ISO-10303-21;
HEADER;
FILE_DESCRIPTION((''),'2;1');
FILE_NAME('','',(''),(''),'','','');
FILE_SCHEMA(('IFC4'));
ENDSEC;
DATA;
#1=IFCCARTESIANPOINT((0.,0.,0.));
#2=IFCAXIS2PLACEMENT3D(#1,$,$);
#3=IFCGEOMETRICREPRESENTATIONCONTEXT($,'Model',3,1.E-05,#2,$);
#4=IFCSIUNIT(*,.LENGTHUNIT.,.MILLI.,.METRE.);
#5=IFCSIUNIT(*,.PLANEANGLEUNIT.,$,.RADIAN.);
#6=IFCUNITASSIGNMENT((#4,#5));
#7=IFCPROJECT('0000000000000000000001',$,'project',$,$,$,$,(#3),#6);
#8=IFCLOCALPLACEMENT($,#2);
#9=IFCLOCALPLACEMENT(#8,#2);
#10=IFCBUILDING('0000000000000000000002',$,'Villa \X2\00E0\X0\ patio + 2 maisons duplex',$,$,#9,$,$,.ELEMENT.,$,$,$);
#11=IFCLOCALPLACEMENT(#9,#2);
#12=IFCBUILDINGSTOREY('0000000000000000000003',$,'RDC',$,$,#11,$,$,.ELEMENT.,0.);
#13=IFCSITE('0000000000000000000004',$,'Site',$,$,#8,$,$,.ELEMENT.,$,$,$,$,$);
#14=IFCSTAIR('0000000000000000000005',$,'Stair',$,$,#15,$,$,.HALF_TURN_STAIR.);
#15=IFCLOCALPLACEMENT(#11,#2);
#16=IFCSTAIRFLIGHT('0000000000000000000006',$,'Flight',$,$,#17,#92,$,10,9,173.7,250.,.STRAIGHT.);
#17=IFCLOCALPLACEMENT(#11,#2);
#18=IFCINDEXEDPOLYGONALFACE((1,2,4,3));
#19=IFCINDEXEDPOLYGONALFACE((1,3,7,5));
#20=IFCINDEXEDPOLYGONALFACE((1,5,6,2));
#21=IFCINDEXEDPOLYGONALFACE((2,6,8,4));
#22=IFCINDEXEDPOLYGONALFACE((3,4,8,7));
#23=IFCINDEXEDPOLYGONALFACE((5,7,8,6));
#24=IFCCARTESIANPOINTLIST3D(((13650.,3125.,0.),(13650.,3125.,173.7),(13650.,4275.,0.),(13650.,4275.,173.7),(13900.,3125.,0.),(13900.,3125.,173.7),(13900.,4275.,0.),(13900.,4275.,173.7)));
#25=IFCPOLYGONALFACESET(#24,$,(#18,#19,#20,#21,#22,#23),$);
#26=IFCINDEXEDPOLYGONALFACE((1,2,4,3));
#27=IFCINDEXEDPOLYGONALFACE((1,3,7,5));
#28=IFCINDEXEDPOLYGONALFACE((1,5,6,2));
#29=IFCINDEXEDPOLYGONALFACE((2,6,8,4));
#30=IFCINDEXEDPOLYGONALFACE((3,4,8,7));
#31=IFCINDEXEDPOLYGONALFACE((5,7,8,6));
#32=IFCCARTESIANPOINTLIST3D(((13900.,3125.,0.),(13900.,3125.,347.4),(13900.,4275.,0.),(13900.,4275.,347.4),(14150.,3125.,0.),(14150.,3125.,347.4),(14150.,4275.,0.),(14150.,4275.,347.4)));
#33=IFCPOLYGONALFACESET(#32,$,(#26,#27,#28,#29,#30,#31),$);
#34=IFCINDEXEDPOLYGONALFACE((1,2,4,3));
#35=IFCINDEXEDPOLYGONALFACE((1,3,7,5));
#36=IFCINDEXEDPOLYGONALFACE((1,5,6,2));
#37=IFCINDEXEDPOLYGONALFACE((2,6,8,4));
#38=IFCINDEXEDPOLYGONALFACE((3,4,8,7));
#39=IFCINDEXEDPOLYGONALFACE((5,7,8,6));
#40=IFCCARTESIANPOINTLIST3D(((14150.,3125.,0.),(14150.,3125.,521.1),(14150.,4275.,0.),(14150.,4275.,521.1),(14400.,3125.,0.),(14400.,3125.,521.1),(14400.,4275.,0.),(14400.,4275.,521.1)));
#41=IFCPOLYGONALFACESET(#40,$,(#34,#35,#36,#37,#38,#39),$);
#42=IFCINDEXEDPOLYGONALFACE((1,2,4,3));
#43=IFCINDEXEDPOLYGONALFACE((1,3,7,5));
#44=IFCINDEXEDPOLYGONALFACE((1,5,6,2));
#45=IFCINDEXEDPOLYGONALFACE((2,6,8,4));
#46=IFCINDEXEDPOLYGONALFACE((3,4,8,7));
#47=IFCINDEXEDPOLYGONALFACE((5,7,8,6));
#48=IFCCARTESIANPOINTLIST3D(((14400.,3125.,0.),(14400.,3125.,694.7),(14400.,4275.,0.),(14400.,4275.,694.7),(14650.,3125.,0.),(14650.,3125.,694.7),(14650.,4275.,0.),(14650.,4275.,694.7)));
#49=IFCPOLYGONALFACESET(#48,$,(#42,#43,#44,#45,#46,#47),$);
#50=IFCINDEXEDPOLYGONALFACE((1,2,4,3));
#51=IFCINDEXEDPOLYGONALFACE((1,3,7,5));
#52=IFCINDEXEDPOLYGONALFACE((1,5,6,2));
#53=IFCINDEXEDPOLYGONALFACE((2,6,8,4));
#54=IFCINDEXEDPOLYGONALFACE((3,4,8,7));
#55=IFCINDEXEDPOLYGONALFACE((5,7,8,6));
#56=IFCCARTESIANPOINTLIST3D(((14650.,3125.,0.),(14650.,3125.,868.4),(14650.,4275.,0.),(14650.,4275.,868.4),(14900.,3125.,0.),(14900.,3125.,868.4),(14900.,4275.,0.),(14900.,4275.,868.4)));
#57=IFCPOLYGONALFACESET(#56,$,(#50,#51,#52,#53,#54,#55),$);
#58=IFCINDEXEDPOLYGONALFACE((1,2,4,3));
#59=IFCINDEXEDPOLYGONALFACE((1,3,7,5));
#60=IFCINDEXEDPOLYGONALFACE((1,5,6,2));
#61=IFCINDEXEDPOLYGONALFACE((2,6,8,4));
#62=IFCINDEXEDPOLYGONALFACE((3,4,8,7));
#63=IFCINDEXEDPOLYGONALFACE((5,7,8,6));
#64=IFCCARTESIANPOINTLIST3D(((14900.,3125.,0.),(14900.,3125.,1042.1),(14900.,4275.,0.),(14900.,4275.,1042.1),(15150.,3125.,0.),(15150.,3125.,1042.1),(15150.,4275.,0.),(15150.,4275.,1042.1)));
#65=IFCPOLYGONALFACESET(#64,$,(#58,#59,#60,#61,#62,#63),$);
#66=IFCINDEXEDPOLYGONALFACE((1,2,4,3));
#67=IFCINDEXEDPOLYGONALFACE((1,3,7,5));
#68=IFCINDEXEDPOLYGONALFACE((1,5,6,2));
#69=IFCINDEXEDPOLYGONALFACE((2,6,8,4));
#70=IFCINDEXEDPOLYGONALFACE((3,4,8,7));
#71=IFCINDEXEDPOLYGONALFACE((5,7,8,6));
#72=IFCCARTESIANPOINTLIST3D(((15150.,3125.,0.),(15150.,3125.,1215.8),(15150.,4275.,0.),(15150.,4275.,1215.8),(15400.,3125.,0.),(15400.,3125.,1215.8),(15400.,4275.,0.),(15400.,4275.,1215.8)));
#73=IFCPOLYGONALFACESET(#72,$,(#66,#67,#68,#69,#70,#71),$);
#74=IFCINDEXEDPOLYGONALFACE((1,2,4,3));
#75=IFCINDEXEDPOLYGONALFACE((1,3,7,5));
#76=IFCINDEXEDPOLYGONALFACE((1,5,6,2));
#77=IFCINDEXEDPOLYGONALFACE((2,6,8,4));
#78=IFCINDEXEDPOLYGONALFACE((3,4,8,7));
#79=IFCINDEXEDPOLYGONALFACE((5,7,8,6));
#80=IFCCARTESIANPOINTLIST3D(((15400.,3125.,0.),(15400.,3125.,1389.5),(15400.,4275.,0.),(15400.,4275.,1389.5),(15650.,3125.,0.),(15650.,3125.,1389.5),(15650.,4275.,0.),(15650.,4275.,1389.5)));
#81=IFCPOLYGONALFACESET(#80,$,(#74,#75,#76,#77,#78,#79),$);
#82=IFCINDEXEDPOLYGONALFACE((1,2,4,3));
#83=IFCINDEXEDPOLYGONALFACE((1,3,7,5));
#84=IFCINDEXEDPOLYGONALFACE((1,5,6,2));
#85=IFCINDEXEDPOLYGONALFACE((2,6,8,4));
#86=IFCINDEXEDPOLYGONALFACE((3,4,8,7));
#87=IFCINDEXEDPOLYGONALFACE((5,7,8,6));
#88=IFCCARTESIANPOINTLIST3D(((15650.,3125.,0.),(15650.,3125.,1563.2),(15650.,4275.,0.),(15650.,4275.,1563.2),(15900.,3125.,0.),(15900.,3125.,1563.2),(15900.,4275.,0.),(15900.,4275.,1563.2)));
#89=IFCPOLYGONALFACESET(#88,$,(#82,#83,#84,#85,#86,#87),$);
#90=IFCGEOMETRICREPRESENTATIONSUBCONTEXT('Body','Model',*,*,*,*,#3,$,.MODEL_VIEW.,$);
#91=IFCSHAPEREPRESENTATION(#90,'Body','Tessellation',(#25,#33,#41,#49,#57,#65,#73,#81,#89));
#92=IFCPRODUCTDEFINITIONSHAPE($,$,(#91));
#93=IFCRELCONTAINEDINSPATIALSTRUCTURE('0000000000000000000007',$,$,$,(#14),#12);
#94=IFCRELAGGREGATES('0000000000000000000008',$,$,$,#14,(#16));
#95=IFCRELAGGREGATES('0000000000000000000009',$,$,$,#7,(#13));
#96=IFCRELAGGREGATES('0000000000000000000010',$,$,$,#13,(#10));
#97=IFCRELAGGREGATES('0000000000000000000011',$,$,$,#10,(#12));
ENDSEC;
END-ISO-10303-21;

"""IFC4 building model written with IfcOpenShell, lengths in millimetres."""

from ifc_helpers import new_model, si_unit, frame, frame_2d, origin, place, context, subcontext, project, spatial, rectangle, extrude, element, aggregate, save


model = new_model("IFC4")

# Units and contexts
model_context = context("Model", 3, precision=1e-05, world=origin())
body_context = subcontext(model_context, "Body", "Model", "MODEL_VIEW")
ifc_project = project(units=[si_unit("LENGTHUNIT", "METRE", prefix="MILLI"), si_unit("PLANEANGLEUNIT", "RADIAN")], contexts=[model_context])

# Site, building, storey
site_placement = place(None, origin())
site = spatial("IfcSite", under=ifc_project, at=site_placement, Name="Site", CompositionType="ELEMENT")
building_placement = place(site_placement, origin())
building = spatial("IfcBuilding", under=site, at=building_placement, Name="Villa à patio + 2 maisons duplex", CompositionType="ELEMENT")
storey_placement = place(building_placement, origin())
storey = spatial("IfcBuildingStorey", under=building, at=storey_placement, Name="RDC", CompositionType="ELEMENT", Elevation=0.0)

# Stair, stair flight
stair_placement = place(storey_placement, origin())
stair = element("IfcStair", 1, at=stair_placement, inside=storey, Name="Stair", PredefinedType="HALF_TURN_STAIR")
stair_flight_1_placement = place(stair_placement, frame((13650.0, 3700.0, 0.0), z_axis=(0.0, 0.0, 1.0), x_axis=(1.0, 0.0, 0.0)))
stair_flight_1 = element("IfcStairFlight", 2, at=stair_flight_1_placement, Name="Flight", NumberOfRisers=10, NumberOfTreads=9, PredefinedType="STRAIGHT", RiserHeight=173.7, TreadLength=250.0, context=body_context, shape_type="SweptSolid", body=[
    extrude(rectangle(XDim=250.0, YDim=1150.0, at=frame_2d((125.0, 0.0))), origin(), (0.0, 0.0, 1.0), 173.7),
    extrude(rectangle(XDim=250.0, YDim=1150.0, at=frame_2d((375.0, 0.0))), origin(), (0.0, 0.0, 1.0), 347.4),
    extrude(rectangle(XDim=250.0, YDim=1150.0, at=frame_2d((625.0, 0.0))), origin(), (0.0, 0.0, 1.0), 521.1),
    extrude(rectangle(XDim=250.0, YDim=1150.0, at=frame_2d((875.0, 0.0))), origin(), (0.0, 0.0, 1.0), 694.7),
    extrude(rectangle(XDim=250.0, YDim=1150.0, at=frame_2d((1125.0, 0.0))), origin(), (0.0, 0.0, 1.0), 868.4),
    extrude(rectangle(XDim=250.0, YDim=1150.0, at=frame_2d((1375.0, 0.0))), origin(), (0.0, 0.0, 1.0), 1042.1),
    extrude(rectangle(XDim=250.0, YDim=1150.0, at=frame_2d((1625.0, 0.0))), origin(), (0.0, 0.0, 1.0), 1215.8),
    extrude(rectangle(XDim=250.0, YDim=1150.0, at=frame_2d((1875.0, 0.0))), origin(), (0.0, 0.0, 1.0), 1389.5),
    extrude(rectangle(XDim=250.0, YDim=1150.0, at=frame_2d((2125.0, 0.0))), origin(), (0.0, 0.0, 1.0), 1563.2),
])
aggregate(stair, [stair_flight_1])

save(model, "model.ifc")
